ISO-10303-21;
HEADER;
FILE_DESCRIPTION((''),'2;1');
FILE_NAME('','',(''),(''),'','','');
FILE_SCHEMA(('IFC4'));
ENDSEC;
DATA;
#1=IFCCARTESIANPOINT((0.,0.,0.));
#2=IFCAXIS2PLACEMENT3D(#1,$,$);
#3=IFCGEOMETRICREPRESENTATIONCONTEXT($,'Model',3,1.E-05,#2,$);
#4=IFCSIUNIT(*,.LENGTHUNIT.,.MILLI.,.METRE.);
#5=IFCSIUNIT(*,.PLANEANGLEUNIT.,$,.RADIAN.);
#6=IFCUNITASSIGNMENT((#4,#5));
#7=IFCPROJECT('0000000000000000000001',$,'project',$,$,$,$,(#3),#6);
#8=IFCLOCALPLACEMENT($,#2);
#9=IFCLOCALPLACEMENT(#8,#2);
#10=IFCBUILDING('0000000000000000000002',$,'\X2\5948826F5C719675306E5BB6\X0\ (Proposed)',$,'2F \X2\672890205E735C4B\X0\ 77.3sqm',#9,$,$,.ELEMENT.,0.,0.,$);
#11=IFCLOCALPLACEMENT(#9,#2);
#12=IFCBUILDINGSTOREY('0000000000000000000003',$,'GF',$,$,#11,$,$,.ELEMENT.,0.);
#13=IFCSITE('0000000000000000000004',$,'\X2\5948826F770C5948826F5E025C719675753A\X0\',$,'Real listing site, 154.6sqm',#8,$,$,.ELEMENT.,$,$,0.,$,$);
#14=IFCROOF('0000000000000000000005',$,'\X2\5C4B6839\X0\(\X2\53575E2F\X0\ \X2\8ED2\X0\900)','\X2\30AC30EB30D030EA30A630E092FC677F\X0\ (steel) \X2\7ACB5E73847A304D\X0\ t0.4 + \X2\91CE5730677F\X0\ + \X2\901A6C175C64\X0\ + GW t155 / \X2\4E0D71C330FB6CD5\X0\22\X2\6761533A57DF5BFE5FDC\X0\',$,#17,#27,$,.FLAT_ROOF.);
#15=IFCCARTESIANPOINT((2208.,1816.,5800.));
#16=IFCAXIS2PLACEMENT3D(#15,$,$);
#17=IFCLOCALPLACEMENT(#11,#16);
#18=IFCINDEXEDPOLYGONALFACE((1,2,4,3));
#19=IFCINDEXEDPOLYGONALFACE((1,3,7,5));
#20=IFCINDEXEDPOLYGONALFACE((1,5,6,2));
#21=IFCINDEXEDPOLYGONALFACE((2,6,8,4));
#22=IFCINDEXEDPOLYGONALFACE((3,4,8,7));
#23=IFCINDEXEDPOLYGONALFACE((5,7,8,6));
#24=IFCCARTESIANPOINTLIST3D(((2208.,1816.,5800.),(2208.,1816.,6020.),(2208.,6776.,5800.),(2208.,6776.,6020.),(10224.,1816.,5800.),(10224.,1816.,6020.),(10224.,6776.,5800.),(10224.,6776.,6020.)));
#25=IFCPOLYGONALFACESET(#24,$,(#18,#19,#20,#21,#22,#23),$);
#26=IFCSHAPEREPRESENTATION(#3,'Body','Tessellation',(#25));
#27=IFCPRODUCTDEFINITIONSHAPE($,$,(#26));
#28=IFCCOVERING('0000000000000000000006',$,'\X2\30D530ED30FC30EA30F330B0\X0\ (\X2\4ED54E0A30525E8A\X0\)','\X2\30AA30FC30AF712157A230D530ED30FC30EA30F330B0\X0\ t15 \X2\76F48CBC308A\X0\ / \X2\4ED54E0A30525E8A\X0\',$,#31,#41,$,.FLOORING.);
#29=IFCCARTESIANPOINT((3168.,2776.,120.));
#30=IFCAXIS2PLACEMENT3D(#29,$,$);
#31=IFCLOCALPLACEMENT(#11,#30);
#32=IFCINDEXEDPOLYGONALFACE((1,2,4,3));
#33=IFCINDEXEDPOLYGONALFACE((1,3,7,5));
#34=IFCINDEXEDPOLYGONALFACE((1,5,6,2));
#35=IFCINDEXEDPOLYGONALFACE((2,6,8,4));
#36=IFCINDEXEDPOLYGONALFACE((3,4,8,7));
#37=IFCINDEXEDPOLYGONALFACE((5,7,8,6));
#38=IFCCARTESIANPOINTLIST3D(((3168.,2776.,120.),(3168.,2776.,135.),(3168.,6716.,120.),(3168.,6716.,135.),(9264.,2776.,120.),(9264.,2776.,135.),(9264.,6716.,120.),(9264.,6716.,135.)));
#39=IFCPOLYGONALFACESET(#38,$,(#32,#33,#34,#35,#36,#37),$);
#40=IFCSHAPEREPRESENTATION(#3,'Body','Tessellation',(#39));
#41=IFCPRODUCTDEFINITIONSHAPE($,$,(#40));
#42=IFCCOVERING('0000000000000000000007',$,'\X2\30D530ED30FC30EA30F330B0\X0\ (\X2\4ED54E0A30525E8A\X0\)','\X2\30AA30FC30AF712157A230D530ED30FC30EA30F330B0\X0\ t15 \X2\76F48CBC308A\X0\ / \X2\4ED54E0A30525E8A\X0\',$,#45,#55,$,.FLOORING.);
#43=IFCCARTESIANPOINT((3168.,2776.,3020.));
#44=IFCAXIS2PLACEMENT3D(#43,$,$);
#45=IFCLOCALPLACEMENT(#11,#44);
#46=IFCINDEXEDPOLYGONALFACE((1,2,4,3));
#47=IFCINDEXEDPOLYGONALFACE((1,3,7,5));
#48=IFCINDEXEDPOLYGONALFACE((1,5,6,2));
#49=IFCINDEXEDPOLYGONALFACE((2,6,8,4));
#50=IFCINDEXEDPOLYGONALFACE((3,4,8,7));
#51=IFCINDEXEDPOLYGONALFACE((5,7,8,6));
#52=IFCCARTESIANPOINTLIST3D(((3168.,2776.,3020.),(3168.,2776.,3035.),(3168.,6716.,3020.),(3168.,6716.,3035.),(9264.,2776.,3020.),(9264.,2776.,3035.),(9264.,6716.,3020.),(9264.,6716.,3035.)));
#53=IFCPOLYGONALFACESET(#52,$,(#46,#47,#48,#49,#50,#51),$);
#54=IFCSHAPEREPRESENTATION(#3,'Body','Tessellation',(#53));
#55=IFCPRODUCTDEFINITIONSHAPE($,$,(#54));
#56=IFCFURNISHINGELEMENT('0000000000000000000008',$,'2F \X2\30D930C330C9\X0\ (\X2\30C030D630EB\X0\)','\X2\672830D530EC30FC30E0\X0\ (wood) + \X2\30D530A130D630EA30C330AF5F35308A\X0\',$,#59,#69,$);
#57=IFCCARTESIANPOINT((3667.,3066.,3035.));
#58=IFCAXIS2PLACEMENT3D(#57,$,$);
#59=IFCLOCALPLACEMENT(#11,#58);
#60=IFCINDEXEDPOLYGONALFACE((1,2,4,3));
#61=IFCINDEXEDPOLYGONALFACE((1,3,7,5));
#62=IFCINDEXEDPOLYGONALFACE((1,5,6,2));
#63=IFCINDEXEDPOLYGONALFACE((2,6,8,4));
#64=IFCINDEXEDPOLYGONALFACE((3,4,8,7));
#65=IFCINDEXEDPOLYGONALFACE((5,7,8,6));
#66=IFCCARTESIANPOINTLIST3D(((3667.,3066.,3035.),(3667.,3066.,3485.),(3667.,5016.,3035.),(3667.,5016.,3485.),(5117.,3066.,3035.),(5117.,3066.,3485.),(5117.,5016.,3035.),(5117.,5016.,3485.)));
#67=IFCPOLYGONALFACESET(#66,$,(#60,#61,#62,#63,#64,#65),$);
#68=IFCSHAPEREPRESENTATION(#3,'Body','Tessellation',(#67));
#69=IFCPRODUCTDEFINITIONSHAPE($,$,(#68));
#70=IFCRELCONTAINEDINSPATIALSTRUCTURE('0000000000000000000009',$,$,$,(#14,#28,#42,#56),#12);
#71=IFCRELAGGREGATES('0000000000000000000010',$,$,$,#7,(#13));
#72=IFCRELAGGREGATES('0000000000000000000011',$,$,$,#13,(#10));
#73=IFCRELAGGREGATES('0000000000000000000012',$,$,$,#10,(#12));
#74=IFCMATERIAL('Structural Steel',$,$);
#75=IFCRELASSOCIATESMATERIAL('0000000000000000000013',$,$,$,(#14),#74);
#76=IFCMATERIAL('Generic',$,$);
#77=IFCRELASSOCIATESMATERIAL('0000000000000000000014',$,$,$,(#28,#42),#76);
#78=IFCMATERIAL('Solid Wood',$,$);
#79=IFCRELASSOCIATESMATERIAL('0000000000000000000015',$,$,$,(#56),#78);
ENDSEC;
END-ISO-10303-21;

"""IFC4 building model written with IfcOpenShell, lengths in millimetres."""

from ifc_helpers import new_model, si_unit, frame, frame_2d, origin, place, context, project, spatial, rectangle, extrude, material, element, save


model = new_model("IFC4")

# Units and contexts
model_context = context("Model", 3, precision=1e-05, world=origin())
ifc_project = project(units=[si_unit("LENGTHUNIT", "METRE", prefix="MILLI"), si_unit("PLANEANGLEUNIT", "RADIAN")], contexts=[model_context])

# Site, building, storey
site_placement = place(None, origin())
site = spatial("IfcSite", under=ifc_project, at=site_placement, Name="奈良県奈良市山陵町", ObjectType="Real listing site, 154.6sqm", CompositionType="ELEMENT", RefElevation=0.0)
building_placement = place(site_placement, origin())
building = spatial("IfcBuilding", under=site, at=building_placement, Name="奈良山陵の家 (Proposed)", ObjectType="2F 木造平屋 77.3sqm", CompositionType="ELEMENT", ElevationOfRefHeight=0.0, ElevationOfTerrain=0.0)
storey_placement = place(building_placement, origin())
storey = spatial("IfcBuildingStorey", under=building, at=storey_placement, Name="GF", CompositionType="ELEMENT", Elevation=0.0)

# Shared definitions
ifc_material_1 = material(Name="Solid Wood")

# Roof
ifc_material_2 = material(Name="Structural Steel")
for number, where, name in (
    (1, (2208.0, 1816.0, 5800.0), "屋根(南帯 軒900)"),
):
    element("IfcRoof", number, at=place(storey_placement, frame(where)), inside=storey, material=ifc_material_2, Name=name, Description="ガルバリウム鋼板 (steel) 立平葺き t0.4 + 野地板 + 通気層 + GW t155 / 不燃・法22条区域対応", PredefinedType="FLAT_ROOF", context=model_context, shape_type="SweptSolid", body=[
        extrude(rectangle(XDim=8016.0, YDim=4960.0, at=frame_2d((4008.0, 2480.0))), frame((2208.0, 1816.0, 5800.0)), (0.0, 0.0, 1.0), 220.0),
    ])

# Coverings
ifc_material_3 = material(Name="Generic")
covering_1_placement = place(storey_placement, frame((3168.0, 2776.0, 120.0)))
element("IfcCovering", 2, at=covering_1_placement, inside=storey, material=ifc_material_3, Name="フローリング (仕上げ床)", Description="オーク無垢フローリング t15 直貼り / 仕上げ床", PredefinedType="FLOORING", context=model_context, shape_type="SweptSolid", body=[
    extrude(rectangle(XDim=6096.0, YDim=3940.0, at=frame_2d((3048.0, 1970.0))), frame((3168.0, 2776.0, 120.0)), (0.0, 0.0, 1.0), 15.0),
])
covering_2_placement = place(storey_placement, frame((3168.0, 2776.0, 3020.0)))
element("IfcCovering", 3, at=covering_2_placement, inside=storey, material=ifc_material_3, Name="フローリング (仕上げ床)", Description="オーク無垢フローリング t15 直貼り / 仕上げ床", PredefinedType="FLOORING", context=model_context, shape_type="SweptSolid", body=[
    extrude(rectangle(XDim=6096.0, YDim=3940.0, at=frame_2d((3048.0, 1970.0))), frame((3168.0, 2776.0, 3020.0)), (0.0, 0.0, 1.0), 15.0),
])

# Furnishing element
furnishing_placement = place(storey_placement, frame((3667.0, 3066.0, 3035.0)))
element("IfcFurnishingElement", 4, at=furnishing_placement, inside=storey, material=ifc_material_1, Name="2F ベッド (ダブル)", Description="木フレーム (wood) + ファブリック張り", context=model_context, shape_type="SweptSolid", body=[
    extrude(rectangle(XDim=1450.0, YDim=1950.0, at=frame_2d((725.0, 975.0))), frame((3667.0, 3066.0, 3035.0)), (0.0, 0.0, 1.0), 450.0),
])

save(model, "model.ifc")
